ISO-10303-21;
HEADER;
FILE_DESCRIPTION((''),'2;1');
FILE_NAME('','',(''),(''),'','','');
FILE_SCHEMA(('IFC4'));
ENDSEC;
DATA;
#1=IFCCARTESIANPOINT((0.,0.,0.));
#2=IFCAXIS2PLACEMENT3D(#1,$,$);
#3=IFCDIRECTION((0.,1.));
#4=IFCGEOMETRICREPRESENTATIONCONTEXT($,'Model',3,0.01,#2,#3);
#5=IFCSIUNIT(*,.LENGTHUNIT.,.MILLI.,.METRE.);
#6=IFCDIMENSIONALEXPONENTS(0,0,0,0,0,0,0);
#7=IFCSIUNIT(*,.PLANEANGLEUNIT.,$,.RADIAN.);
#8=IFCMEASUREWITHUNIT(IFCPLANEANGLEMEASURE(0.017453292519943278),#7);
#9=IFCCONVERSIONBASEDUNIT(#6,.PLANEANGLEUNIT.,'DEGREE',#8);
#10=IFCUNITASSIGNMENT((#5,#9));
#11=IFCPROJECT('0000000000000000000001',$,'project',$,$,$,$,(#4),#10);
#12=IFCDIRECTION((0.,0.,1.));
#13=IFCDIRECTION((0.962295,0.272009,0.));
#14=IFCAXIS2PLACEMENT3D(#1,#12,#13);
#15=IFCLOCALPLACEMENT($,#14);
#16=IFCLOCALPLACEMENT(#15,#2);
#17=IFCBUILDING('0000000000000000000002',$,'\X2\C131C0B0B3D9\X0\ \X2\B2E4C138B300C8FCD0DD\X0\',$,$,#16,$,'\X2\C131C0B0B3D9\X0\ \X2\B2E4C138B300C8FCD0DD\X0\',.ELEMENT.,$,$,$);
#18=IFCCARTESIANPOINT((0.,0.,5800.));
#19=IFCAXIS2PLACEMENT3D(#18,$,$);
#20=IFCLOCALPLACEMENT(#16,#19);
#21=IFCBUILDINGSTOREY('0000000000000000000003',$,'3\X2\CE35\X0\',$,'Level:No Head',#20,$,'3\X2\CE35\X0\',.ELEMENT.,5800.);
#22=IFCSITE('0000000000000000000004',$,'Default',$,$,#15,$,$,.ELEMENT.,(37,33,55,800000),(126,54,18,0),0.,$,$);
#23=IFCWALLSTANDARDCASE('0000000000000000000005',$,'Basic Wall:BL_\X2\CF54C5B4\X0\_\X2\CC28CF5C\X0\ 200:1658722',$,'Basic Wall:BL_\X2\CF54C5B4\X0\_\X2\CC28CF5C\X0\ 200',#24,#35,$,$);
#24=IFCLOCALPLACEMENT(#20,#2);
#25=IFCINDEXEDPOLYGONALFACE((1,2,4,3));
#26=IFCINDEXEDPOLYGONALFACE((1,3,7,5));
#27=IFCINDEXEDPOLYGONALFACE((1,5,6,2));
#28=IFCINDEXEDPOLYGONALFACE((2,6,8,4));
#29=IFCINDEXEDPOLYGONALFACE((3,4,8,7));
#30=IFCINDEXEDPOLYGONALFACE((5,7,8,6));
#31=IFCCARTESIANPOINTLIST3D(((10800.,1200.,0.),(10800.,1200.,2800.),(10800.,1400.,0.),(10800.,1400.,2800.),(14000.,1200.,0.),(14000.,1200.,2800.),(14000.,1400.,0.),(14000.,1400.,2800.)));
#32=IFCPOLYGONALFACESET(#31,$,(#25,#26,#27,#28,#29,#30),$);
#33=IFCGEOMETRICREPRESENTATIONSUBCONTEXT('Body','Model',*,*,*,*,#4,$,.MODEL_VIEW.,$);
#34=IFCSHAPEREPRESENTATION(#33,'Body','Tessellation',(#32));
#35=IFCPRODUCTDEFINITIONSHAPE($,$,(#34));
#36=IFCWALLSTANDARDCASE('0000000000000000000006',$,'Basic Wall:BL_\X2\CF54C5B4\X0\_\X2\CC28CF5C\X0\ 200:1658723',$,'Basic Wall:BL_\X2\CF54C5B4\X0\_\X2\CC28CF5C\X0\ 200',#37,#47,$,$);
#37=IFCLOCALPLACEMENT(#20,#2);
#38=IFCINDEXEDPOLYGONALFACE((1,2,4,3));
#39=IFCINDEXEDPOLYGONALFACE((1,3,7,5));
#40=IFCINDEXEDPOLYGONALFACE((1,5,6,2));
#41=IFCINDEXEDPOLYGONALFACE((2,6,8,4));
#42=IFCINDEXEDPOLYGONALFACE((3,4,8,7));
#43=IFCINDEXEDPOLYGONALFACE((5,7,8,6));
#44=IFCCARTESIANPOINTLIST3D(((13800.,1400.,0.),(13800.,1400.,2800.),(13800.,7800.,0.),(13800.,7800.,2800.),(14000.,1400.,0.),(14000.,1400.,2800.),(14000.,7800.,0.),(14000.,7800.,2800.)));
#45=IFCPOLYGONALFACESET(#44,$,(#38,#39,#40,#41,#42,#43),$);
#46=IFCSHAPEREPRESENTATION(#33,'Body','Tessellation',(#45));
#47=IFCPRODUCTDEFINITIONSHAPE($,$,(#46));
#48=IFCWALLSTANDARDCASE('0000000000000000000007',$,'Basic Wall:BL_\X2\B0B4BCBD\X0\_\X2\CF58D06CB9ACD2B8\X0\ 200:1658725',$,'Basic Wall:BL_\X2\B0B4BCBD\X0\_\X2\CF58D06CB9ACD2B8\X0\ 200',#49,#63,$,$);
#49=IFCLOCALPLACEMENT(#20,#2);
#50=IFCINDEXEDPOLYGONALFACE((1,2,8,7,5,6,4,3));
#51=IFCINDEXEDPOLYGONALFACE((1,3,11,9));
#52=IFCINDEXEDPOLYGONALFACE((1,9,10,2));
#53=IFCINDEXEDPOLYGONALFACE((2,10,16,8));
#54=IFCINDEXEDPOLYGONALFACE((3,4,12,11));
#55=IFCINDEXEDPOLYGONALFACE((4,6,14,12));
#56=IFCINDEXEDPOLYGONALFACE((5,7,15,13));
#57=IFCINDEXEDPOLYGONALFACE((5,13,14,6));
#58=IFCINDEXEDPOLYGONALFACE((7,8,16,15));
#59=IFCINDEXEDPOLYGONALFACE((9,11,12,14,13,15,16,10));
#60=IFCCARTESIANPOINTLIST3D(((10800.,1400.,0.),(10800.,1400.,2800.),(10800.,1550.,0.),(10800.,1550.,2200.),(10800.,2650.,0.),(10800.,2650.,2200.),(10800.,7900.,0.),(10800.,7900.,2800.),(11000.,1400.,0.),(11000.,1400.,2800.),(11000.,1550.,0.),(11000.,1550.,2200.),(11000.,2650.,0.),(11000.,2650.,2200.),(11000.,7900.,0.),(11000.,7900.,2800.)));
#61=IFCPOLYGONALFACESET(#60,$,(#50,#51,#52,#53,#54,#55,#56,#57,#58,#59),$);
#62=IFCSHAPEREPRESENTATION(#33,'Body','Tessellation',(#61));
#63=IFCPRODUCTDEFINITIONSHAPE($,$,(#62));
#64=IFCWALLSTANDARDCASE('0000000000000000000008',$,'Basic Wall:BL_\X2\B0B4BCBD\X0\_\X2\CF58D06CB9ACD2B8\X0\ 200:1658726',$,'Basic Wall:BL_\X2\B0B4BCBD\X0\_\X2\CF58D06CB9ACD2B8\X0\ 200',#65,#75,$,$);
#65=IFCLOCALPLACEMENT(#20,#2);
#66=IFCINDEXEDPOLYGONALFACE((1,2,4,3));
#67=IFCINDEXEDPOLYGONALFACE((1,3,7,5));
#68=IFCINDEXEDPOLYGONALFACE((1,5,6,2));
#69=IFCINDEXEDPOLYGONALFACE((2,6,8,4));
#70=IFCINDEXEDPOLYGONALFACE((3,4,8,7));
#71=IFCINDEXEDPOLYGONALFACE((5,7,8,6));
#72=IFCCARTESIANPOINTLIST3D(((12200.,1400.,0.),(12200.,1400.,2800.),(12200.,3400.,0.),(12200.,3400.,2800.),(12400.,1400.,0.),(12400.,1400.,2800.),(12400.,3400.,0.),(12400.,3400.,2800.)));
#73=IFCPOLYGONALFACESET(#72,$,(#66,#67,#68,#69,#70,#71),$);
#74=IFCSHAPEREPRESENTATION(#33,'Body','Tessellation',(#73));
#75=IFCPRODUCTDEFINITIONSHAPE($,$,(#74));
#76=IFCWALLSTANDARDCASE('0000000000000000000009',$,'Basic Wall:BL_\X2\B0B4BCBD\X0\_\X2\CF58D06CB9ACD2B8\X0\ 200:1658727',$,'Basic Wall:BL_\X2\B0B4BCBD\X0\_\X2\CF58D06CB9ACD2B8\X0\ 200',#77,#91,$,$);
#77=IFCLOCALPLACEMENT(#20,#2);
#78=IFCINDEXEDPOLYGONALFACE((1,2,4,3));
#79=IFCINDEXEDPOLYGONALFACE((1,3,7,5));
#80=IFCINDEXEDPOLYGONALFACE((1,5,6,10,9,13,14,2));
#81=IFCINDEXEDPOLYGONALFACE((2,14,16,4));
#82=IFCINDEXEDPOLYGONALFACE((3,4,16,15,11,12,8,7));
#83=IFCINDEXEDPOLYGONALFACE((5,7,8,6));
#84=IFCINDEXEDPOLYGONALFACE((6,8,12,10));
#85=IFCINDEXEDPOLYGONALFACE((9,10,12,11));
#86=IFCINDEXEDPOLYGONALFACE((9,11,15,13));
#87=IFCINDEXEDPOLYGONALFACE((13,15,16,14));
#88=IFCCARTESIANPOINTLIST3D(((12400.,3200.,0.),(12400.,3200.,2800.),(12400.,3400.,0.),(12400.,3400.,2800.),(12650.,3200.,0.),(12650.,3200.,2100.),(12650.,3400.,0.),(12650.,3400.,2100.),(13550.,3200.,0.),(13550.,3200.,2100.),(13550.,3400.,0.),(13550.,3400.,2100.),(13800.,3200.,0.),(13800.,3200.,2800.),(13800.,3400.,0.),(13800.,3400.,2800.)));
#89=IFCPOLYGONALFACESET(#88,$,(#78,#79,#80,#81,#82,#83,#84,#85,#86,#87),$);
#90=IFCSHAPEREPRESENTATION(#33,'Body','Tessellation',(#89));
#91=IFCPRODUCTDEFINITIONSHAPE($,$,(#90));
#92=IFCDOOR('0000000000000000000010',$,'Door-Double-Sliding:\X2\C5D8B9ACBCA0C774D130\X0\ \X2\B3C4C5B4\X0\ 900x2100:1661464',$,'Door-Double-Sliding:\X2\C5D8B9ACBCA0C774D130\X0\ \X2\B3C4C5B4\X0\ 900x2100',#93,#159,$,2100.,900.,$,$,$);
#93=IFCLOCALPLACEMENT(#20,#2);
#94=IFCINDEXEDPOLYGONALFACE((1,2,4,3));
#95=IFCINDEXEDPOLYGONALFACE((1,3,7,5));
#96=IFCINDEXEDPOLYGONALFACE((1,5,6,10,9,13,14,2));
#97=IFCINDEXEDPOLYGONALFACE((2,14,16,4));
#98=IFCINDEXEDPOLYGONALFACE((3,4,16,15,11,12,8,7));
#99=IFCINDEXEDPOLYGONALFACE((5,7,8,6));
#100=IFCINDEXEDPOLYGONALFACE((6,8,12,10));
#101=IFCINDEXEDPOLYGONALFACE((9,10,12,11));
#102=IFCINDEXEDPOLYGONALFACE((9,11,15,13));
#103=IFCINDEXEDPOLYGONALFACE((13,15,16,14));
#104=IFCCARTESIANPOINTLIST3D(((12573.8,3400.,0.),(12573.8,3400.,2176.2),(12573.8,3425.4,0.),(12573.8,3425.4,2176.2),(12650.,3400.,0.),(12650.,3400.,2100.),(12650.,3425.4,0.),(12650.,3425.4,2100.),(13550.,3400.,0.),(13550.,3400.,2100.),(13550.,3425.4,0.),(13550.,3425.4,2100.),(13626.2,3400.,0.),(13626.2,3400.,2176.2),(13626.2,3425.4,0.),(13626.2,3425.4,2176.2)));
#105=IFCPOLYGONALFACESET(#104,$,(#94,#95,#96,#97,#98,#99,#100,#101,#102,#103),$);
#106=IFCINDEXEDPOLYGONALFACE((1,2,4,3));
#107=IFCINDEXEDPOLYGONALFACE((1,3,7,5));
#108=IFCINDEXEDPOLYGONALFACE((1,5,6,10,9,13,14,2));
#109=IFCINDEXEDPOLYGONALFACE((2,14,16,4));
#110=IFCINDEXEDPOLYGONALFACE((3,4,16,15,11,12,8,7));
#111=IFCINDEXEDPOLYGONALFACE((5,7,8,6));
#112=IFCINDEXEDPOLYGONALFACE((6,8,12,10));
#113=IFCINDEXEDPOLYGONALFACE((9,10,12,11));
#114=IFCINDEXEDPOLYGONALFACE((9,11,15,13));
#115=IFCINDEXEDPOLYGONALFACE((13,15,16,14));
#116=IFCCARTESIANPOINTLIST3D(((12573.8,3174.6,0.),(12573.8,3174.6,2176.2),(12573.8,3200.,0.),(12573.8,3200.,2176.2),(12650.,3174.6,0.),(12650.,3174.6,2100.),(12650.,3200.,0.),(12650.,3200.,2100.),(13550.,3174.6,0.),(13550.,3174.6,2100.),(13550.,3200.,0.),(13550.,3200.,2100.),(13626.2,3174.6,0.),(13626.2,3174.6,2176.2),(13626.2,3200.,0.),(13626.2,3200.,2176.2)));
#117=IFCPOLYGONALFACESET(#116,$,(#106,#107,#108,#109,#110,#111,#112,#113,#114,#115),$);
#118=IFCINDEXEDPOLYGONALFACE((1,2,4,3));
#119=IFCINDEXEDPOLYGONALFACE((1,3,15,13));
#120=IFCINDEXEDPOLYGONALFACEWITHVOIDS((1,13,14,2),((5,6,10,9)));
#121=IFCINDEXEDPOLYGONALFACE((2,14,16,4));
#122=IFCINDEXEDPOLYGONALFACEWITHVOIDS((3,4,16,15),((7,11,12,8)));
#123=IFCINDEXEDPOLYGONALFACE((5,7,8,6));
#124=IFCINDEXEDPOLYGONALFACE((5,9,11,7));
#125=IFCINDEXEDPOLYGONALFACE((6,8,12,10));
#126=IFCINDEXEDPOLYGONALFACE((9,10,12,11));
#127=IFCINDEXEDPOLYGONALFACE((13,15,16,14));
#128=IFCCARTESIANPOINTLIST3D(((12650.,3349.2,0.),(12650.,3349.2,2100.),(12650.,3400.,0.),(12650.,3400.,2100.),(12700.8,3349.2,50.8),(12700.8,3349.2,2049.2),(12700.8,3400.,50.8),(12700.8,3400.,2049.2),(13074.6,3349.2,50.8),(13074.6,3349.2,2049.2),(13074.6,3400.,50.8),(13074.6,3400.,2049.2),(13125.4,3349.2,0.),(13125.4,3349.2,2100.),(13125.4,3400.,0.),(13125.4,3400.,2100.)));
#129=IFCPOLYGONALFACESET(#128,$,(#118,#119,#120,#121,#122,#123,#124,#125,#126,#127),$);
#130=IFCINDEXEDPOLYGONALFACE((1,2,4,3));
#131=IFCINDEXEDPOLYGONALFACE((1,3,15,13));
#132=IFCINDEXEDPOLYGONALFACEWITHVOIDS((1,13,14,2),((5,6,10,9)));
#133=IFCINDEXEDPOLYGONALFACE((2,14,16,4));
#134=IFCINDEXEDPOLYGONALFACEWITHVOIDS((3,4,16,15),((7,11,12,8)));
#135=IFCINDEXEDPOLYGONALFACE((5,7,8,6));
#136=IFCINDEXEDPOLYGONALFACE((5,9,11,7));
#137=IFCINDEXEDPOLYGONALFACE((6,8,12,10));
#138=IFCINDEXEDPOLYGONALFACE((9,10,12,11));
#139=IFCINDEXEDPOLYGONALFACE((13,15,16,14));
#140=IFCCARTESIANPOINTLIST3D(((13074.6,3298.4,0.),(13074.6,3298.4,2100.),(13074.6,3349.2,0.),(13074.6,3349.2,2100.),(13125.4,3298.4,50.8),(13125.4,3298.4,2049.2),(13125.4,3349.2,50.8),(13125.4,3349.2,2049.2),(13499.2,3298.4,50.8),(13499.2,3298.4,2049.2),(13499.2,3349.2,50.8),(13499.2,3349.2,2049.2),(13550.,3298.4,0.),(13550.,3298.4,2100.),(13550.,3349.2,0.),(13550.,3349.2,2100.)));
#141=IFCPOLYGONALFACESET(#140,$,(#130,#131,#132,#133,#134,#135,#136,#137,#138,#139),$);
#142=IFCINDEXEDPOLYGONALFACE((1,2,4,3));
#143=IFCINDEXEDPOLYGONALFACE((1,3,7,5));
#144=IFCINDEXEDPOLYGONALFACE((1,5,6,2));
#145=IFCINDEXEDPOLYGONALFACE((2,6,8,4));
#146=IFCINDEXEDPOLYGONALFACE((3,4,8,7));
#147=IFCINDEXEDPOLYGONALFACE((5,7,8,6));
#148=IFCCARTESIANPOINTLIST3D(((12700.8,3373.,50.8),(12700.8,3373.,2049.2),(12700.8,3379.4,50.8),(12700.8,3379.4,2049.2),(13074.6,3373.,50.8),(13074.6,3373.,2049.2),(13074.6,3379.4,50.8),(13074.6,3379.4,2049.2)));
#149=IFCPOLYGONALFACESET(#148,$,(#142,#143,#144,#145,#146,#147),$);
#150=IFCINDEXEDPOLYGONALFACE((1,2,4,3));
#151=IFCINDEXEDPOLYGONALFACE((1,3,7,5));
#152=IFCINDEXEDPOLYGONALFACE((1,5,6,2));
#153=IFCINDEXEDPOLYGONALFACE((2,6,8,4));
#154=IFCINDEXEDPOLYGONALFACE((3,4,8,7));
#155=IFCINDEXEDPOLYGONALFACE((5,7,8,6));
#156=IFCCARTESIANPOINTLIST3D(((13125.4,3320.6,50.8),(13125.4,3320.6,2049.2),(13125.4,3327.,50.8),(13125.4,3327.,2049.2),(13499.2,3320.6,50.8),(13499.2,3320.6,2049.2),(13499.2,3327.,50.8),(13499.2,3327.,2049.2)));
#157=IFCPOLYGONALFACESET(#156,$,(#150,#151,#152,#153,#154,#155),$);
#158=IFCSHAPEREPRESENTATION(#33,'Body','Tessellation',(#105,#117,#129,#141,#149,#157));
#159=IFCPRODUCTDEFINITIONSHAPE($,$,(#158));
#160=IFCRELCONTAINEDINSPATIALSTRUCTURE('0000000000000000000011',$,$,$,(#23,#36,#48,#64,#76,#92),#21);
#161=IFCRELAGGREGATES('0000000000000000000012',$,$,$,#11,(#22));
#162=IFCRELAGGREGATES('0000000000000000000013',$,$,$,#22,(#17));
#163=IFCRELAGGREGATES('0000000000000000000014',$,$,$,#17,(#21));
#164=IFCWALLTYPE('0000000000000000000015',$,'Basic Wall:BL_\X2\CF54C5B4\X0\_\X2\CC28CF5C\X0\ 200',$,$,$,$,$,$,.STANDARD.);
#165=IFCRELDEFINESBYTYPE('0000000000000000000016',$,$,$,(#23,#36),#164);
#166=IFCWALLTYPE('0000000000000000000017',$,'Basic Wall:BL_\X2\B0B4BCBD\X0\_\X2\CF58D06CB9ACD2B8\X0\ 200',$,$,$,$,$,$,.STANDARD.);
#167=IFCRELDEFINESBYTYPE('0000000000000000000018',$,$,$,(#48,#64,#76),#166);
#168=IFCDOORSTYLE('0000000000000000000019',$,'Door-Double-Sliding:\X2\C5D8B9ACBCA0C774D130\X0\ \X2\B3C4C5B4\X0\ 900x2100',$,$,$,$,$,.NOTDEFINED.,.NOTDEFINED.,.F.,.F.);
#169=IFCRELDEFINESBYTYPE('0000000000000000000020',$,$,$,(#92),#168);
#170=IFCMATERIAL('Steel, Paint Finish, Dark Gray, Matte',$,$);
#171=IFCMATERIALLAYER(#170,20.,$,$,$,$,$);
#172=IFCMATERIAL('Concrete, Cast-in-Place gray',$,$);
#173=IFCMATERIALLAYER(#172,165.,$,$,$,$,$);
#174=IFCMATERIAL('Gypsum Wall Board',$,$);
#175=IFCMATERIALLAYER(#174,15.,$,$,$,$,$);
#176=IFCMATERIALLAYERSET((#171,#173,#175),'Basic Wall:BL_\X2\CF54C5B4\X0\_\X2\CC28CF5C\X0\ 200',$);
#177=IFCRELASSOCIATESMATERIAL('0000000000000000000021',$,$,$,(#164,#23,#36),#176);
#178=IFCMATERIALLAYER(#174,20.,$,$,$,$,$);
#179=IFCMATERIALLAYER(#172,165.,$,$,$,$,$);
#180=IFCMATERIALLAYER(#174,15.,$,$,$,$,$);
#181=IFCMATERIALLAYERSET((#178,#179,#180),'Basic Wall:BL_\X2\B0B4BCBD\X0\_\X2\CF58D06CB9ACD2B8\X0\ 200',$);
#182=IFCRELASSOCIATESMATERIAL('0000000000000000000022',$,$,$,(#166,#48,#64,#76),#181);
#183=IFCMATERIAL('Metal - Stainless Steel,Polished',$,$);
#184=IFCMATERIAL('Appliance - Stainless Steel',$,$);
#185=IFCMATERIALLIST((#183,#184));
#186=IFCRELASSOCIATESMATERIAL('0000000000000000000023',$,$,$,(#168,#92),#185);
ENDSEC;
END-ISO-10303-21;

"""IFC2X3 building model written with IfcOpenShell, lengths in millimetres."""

from ifc_helpers import new_model, entity, si_unit, converted_unit, direction, frame, frame_2d, origin, place, context, subcontext, project, spatial, polyline, rectangle, outline, extrude, source, transform, mapped, material, material_list, layer, layer_set, layer_usage, type_object, type_shapes, element, fill, save


model = new_model("IFC2X3")

# Units and contexts
model_context = context("Model", 3, precision=0.01, world=origin(), true_north=direction((0.0, 1.0)))
body_context = subcontext(model_context, "Body", "Model", "MODEL_VIEW")
ifc_project = project(units=[si_unit("LENGTHUNIT", "METRE", prefix="MILLI"), converted_unit("PLANEANGLEUNIT", "DEGREE", entity("IfcPlaneAngleMeasure", 0.017453292519943278), si_unit("PLANEANGLEUNIT", "RADIAN"), dimensions=[0, 0, 0, 0, 0, 0, 0])], contexts=[model_context])

# Site, building, storey
site_placement = place(None, frame((0.0, 0.0, 0.0), z_axis=(0.0, 0.0, 1.0), x_axis=(0.962295, 0.272009, 0.0)))
site = spatial("IfcSite", under=ifc_project, at=site_placement, Name="Default", CompositionType="ELEMENT", RefLatitude=(37, 33, 55, 800000), RefLongitude=(126, 54, 18, 0), RefElevation=0.0)
building_placement = place(site_placement, origin())
building = spatial("IfcBuilding", under=site, at=building_placement, Name="성산동 다세대주택", LongName="성산동 다세대주택", CompositionType="ELEMENT")
storey_placement = place(building_placement, frame((0.0, 0.0, 5800.0)))
storey = spatial("IfcBuildingStorey", under=building, at=storey_placement, Name="3층", ObjectType="Level:No Head", LongName="3층", CompositionType="ELEMENT", Elevation=5800.0)

# Walls
ifc_material_1 = material(Name="Steel, Paint Finish, Dark Gray, Matte")
ifc_layer_1 = layer(ifc_material_1, 20.0)
ifc_material_2 = material(Name="Concrete, Cast-in-Place gray")
ifc_layer_2 = layer(ifc_material_2, 165.0)
ifc_material_3 = material(Name="Gypsum Wall Board")
ifc_layer_3 = layer(ifc_material_3, 15.0)
ifc_layer_set_1 = layer_set([ifc_layer_1, ifc_layer_2, ifc_layer_3], Name="Basic Wall:BL_코어_차콜 200")
ifc_layer_usage_1 = layer_usage(ifc_layer_set_1, "AXIS2", "POSITIVE", -100.0)
wall_type_1 = type_object("IfcWallType", Name="Basic Wall:BL_코어_차콜 200", PredefinedType="STANDARD", material=ifc_layer_set_1)
wall_1_placement = place(storey_placement, frame((10800.0, 1300.0, 0.0)))
element("IfcWallStandardCase", 1, at=wall_1_placement, inside=storey, type_object=wall_type_1, material=ifc_layer_usage_1, Name="Basic Wall:BL_코어_차콜 200:1658722", ObjectType="Basic Wall:BL_코어_차콜 200", context=body_context, shape_type="SweptSolid", body=[
    extrude(rectangle(XDim=3200.0, YDim=200.0, at=frame_2d((1600.0, 0.0), x_axis=(-1.0, 0.0))), origin(), (0.0, 0.0, 1.0), 2800.0),
])
ifc_layer_usage_2 = layer_usage(ifc_layer_set_1, "AXIS2", "POSITIVE", -100.0)
wall_2_placement = place(storey_placement, frame((13900.0, 1400.0, 0.0), z_axis=(0.0, 0.0, 1.0), x_axis=(0.0, 1.0, 0.0)))
element("IfcWallStandardCase", 2, at=wall_2_placement, inside=storey, type_object=wall_type_1, material=ifc_layer_usage_2, Name="Basic Wall:BL_코어_차콜 200:1658723", ObjectType="Basic Wall:BL_코어_차콜 200", context=body_context, shape_type="SweptSolid", body=[
    extrude(rectangle(XDim=6400.0, YDim=200.0, at=frame_2d((3200.0, 0.0), x_axis=(-1.0, 0.0))), origin(), (0.0, 0.0, 1.0), 2800.0),
])

# Wall, openings
ifc_layer_4 = layer(ifc_material_3, 20.0)
ifc_layer_5 = layer(ifc_material_2, 165.0)
ifc_layer_6 = layer(ifc_material_3, 15.0)
ifc_layer_set_2 = layer_set([ifc_layer_4, ifc_layer_5, ifc_layer_6], Name="Basic Wall:BL_내벽_콘크리트 200")
ifc_layer_usage_3 = layer_usage(ifc_layer_set_2, "AXIS2", "NEGATIVE", 100.0)
wall_type_2 = type_object("IfcWallType", Name="Basic Wall:BL_내벽_콘크리트 200", PredefinedType="STANDARD", material=ifc_layer_set_2)
wall_3_placement = place(storey_placement, frame((10900.0, 7900.0, 0.0), z_axis=(0.0, 0.0, 1.0), x_axis=(0.0, -1.0, 0.0)))
wall_3 = element("IfcWallStandardCase", 3, at=wall_3_placement, inside=storey, type_object=wall_type_2, material=ifc_layer_usage_3, Name="Basic Wall:BL_내벽_콘크리트 200:1658725", ObjectType="Basic Wall:BL_내벽_콘크리트 200", context=body_context, shape_type="SweptSolid", body=[
    extrude(rectangle(XDim=6500.0, YDim=200.0, at=frame_2d((3250.0, 0.0), x_axis=(1.0, 0.0))), origin(), (0.0, 0.0, 1.0), 2800.0),
])
opening_1_placement = place(wall_3_placement, origin())
element("IfcOpeningElement", 4, at=opening_1_placement, cuts=wall_3, ObjectType="Opening", context=body_context, shape_type="SweptSolid", body=[
    extrude(rectangle(XDim=2200.0, YDim=1100.0, at=frame_2d((0.0, 0.0), x_axis=(0.0, 1.0))), frame((5800.0, -1624.0, 3900.0), z_axis=(0.0, 1.0, 0.0), x_axis=(-1.0, 0.0, 0.0)), (0.0, 0.0, 1.0), 3048.0),
])
opening_2_placement = place(wall_3_placement, frame((5250.0, -100.0, 0.0)))
element("IfcOpeningElement", 5, at=opening_2_placement, cuts=wall_3, ObjectType="Opening", context=body_context, shape_type="SweptSolid", body=[
    extrude(rectangle(XDim=2200.0, YDim=1100.0, at=frame_2d((1100.0, 550.0), x_axis=(1.0, 0.0))), frame((0.0, 0.0, 0.0), z_axis=(0.0, 1.0, 0.0), x_axis=(0.0, 0.0, 1.0)), (0.0, 0.0, 1.0), 200.0),
])

# Wall
ifc_layer_usage_4 = layer_usage(ifc_layer_set_2, "AXIS2", "NEGATIVE", 100.0)
wall_4_placement = place(storey_placement, frame((12300.0, 1400.0, 0.0), z_axis=(0.0, 0.0, 1.0), x_axis=(0.0, 1.0, 0.0)))
element("IfcWallStandardCase", 6, at=wall_4_placement, inside=storey, type_object=wall_type_2, material=ifc_layer_usage_4, Name="Basic Wall:BL_내벽_콘크리트 200:1658726", ObjectType="Basic Wall:BL_내벽_콘크리트 200", context=body_context, shape_type="SweptSolid", body=[
    extrude(rectangle(XDim=2000.0, YDim=200.0, at=frame_2d((1000.0, 0.0), x_axis=(-1.0, 0.0))), origin(), (0.0, 0.0, 1.0), 2800.0),
])

# Wall, openings, door
ifc_layer_usage_5 = layer_usage(ifc_layer_set_2, "AXIS2", "NEGATIVE", 100.0)
wall_5_placement = place(storey_placement, frame((12400.0, 3300.0, 0.0)))
wall_5 = element("IfcWallStandardCase", 7, at=wall_5_placement, inside=storey, type_object=wall_type_2, material=ifc_layer_usage_5, Name="Basic Wall:BL_내벽_콘크리트 200:1658727", ObjectType="Basic Wall:BL_내벽_콘크리트 200", context=body_context, shape_type="SweptSolid", body=[
    extrude(rectangle(XDim=1400.0, YDim=200.0, at=frame_2d((700.0, 0.0), x_axis=(-1.0, 0.0))), origin(), (0.0, 0.0, 1.0), 2800.0),
])
opening_3_placement = place(wall_5_placement, origin())
element("IfcOpeningElement", 8, at=opening_3_placement, cuts=wall_5, ObjectType="Opening", context=body_context, shape_type="SweptSolid", body=[
    extrude(rectangle(XDim=2100.0, YDim=900.0, at=frame_2d((0.0, 0.0), x_axis=(0.0, 1.0))), frame((700.0, -1624.0, 3850.0), z_axis=(0.0, 1.0, 0.0), x_axis=(1.0, 0.0, 0.0)), (0.0, 0.0, 1.0), 3048.0),
])
opening_4_placement = place(wall_5_placement, frame((250.0, -100.0, 0.0)))
opening_4 = element("IfcOpeningElement", 9, at=opening_4_placement, cuts=wall_5, ObjectType="Opening", context=body_context, shape_type="SweptSolid", body=[
    extrude(rectangle(XDim=2100.0, YDim=900.0, at=frame_2d((1050.0, 450.0), x_axis=(-1.0, 0.0))), frame((0.0, 0.0, 0.0), z_axis=(0.0, 1.0, 0.0), x_axis=(0.0, 0.0, 1.0)), (0.0, 0.0, 1.0), 200.0),
])
ifc_material_4 = material(Name="Metal - Stainless Steel,Polished")
ifc_material_5 = material(Name="Appliance - Stainless Steel")
ifc_material_list_1 = material_list([ifc_material_4, ifc_material_5])
door_style = type_object("IfcDoorStyle", Name="Door-Double-Sliding:엘리베이터 도어 900x2100", ConstructionType="NOTDEFINED", OperationType="NOTDEFINED", ParameterTakesPrecedence=False, Sizeable=False, material=ifc_material_list_1)
shared_shape_1 = source(origin(), body_context, "Body", "SweptSolid", [
    extrude(outline(polyline([(-526.2, -1069.1), (-450.0, -1069.1), (-450.0, 1030.9), (450.0, 1031.0), (450.0, -1069.0), (526.2, -1069.0), (526.2, 1107.1), (-526.2, 1107.1), (-526.2, -1069.1)])), frame((450.0, 200.0, 1069.0), z_axis=(0.0, 1.0, 0.0), x_axis=(-1.0, 0.0, 0.0)), (0.0, 0.0, 1.0), 25.4),
    extrude(outline(polyline([(-1069.0, -526.2), (1107.1, -526.2), (1107.1, 526.2), (-1069.0, 526.2), (-1069.0, 450.0), (1030.9, 450.0), (1030.9, -450.0), (-1069.0, -450.0), (-1069.0, -526.2)])), frame((450.0, -25.4, 1069.0), z_axis=(0.0, 1.0, 0.0), x_axis=(0.0, 0.0, 1.0)), (0.0, 0.0, 1.0), 25.4),
    extrude(outline(polyline([(-1050.0, -237.7), (1050.0, -237.7), (1050.0, 237.7), (-1050.0, 237.7), (-1050.0, -237.7)]), holes=[polyline([(-999.2, -186.9), (-999.2, 186.9), (999.2, 186.9), (999.2, -186.9), (-999.2, -186.9)])]), frame((237.7, 149.2, 1050.0), z_axis=(0.0, 1.0, 0.0), x_axis=(0.0, 0.0, -1.0)), (0.0, 0.0, 1.0), 50.8),
    extrude(outline(polyline([(-237.7, -1050.0), (237.7, -1050.0), (237.7, 1050.0), (-237.7, 1050.0), (-237.7, -1050.0)]), holes=[polyline([(-186.9, -999.2), (-186.9, 999.2), (186.9, 999.2), (186.9, -999.2), (-186.9, -999.2)])]), frame((662.3, 98.4, 1050.0), z_axis=(0.0, 1.0, 0.0), x_axis=(1.0, 0.0, 0.0)), (0.0, 0.0, 1.0), 50.8),
    extrude(rectangle(XDim=6.4, YDim=373.8, at=frame_2d((0.0, 0.0), x_axis=(1.0, 0.0))), frame((237.7, 176.2, 50.8), z_axis=(0.0, 0.0, 1.0), x_axis=(0.0, 1.0, 0.0)), (0.0, 0.0, 1.0), 1998.4),
    extrude(rectangle(XDim=6.3, YDim=373.8, at=frame_2d((0.0, 0.0), x_axis=(1.0, 0.0))), frame((662.3, 123.8, 50.8), z_axis=(0.0, 0.0, 1.0), x_axis=(0.0, -1.0, 0.0)), (0.0, 0.0, 1.0), 1998.4),
])
type_shapes(door_style, [shared_shape_1])
door_placement = place(opening_4_placement, origin())
door = element("IfcDoor", 10, at=door_placement, inside=storey, type_object=door_style, material=ifc_material_list_1, Name="Door-Double-Sliding:엘리베이터 도어 900x2100:1661464", ObjectType="Door-Double-Sliding:엘리베이터 도어 900x2100", OverallHeight=2100.0, OverallWidth=900.0, context=body_context, shape_type="MappedRepresentation", body=[
    mapped(shared_shape_1, transform((0.0, 0.0, 0.0), scale=1.0)),
])
fill(opening_4, door)

save(model, "model.ifc")
